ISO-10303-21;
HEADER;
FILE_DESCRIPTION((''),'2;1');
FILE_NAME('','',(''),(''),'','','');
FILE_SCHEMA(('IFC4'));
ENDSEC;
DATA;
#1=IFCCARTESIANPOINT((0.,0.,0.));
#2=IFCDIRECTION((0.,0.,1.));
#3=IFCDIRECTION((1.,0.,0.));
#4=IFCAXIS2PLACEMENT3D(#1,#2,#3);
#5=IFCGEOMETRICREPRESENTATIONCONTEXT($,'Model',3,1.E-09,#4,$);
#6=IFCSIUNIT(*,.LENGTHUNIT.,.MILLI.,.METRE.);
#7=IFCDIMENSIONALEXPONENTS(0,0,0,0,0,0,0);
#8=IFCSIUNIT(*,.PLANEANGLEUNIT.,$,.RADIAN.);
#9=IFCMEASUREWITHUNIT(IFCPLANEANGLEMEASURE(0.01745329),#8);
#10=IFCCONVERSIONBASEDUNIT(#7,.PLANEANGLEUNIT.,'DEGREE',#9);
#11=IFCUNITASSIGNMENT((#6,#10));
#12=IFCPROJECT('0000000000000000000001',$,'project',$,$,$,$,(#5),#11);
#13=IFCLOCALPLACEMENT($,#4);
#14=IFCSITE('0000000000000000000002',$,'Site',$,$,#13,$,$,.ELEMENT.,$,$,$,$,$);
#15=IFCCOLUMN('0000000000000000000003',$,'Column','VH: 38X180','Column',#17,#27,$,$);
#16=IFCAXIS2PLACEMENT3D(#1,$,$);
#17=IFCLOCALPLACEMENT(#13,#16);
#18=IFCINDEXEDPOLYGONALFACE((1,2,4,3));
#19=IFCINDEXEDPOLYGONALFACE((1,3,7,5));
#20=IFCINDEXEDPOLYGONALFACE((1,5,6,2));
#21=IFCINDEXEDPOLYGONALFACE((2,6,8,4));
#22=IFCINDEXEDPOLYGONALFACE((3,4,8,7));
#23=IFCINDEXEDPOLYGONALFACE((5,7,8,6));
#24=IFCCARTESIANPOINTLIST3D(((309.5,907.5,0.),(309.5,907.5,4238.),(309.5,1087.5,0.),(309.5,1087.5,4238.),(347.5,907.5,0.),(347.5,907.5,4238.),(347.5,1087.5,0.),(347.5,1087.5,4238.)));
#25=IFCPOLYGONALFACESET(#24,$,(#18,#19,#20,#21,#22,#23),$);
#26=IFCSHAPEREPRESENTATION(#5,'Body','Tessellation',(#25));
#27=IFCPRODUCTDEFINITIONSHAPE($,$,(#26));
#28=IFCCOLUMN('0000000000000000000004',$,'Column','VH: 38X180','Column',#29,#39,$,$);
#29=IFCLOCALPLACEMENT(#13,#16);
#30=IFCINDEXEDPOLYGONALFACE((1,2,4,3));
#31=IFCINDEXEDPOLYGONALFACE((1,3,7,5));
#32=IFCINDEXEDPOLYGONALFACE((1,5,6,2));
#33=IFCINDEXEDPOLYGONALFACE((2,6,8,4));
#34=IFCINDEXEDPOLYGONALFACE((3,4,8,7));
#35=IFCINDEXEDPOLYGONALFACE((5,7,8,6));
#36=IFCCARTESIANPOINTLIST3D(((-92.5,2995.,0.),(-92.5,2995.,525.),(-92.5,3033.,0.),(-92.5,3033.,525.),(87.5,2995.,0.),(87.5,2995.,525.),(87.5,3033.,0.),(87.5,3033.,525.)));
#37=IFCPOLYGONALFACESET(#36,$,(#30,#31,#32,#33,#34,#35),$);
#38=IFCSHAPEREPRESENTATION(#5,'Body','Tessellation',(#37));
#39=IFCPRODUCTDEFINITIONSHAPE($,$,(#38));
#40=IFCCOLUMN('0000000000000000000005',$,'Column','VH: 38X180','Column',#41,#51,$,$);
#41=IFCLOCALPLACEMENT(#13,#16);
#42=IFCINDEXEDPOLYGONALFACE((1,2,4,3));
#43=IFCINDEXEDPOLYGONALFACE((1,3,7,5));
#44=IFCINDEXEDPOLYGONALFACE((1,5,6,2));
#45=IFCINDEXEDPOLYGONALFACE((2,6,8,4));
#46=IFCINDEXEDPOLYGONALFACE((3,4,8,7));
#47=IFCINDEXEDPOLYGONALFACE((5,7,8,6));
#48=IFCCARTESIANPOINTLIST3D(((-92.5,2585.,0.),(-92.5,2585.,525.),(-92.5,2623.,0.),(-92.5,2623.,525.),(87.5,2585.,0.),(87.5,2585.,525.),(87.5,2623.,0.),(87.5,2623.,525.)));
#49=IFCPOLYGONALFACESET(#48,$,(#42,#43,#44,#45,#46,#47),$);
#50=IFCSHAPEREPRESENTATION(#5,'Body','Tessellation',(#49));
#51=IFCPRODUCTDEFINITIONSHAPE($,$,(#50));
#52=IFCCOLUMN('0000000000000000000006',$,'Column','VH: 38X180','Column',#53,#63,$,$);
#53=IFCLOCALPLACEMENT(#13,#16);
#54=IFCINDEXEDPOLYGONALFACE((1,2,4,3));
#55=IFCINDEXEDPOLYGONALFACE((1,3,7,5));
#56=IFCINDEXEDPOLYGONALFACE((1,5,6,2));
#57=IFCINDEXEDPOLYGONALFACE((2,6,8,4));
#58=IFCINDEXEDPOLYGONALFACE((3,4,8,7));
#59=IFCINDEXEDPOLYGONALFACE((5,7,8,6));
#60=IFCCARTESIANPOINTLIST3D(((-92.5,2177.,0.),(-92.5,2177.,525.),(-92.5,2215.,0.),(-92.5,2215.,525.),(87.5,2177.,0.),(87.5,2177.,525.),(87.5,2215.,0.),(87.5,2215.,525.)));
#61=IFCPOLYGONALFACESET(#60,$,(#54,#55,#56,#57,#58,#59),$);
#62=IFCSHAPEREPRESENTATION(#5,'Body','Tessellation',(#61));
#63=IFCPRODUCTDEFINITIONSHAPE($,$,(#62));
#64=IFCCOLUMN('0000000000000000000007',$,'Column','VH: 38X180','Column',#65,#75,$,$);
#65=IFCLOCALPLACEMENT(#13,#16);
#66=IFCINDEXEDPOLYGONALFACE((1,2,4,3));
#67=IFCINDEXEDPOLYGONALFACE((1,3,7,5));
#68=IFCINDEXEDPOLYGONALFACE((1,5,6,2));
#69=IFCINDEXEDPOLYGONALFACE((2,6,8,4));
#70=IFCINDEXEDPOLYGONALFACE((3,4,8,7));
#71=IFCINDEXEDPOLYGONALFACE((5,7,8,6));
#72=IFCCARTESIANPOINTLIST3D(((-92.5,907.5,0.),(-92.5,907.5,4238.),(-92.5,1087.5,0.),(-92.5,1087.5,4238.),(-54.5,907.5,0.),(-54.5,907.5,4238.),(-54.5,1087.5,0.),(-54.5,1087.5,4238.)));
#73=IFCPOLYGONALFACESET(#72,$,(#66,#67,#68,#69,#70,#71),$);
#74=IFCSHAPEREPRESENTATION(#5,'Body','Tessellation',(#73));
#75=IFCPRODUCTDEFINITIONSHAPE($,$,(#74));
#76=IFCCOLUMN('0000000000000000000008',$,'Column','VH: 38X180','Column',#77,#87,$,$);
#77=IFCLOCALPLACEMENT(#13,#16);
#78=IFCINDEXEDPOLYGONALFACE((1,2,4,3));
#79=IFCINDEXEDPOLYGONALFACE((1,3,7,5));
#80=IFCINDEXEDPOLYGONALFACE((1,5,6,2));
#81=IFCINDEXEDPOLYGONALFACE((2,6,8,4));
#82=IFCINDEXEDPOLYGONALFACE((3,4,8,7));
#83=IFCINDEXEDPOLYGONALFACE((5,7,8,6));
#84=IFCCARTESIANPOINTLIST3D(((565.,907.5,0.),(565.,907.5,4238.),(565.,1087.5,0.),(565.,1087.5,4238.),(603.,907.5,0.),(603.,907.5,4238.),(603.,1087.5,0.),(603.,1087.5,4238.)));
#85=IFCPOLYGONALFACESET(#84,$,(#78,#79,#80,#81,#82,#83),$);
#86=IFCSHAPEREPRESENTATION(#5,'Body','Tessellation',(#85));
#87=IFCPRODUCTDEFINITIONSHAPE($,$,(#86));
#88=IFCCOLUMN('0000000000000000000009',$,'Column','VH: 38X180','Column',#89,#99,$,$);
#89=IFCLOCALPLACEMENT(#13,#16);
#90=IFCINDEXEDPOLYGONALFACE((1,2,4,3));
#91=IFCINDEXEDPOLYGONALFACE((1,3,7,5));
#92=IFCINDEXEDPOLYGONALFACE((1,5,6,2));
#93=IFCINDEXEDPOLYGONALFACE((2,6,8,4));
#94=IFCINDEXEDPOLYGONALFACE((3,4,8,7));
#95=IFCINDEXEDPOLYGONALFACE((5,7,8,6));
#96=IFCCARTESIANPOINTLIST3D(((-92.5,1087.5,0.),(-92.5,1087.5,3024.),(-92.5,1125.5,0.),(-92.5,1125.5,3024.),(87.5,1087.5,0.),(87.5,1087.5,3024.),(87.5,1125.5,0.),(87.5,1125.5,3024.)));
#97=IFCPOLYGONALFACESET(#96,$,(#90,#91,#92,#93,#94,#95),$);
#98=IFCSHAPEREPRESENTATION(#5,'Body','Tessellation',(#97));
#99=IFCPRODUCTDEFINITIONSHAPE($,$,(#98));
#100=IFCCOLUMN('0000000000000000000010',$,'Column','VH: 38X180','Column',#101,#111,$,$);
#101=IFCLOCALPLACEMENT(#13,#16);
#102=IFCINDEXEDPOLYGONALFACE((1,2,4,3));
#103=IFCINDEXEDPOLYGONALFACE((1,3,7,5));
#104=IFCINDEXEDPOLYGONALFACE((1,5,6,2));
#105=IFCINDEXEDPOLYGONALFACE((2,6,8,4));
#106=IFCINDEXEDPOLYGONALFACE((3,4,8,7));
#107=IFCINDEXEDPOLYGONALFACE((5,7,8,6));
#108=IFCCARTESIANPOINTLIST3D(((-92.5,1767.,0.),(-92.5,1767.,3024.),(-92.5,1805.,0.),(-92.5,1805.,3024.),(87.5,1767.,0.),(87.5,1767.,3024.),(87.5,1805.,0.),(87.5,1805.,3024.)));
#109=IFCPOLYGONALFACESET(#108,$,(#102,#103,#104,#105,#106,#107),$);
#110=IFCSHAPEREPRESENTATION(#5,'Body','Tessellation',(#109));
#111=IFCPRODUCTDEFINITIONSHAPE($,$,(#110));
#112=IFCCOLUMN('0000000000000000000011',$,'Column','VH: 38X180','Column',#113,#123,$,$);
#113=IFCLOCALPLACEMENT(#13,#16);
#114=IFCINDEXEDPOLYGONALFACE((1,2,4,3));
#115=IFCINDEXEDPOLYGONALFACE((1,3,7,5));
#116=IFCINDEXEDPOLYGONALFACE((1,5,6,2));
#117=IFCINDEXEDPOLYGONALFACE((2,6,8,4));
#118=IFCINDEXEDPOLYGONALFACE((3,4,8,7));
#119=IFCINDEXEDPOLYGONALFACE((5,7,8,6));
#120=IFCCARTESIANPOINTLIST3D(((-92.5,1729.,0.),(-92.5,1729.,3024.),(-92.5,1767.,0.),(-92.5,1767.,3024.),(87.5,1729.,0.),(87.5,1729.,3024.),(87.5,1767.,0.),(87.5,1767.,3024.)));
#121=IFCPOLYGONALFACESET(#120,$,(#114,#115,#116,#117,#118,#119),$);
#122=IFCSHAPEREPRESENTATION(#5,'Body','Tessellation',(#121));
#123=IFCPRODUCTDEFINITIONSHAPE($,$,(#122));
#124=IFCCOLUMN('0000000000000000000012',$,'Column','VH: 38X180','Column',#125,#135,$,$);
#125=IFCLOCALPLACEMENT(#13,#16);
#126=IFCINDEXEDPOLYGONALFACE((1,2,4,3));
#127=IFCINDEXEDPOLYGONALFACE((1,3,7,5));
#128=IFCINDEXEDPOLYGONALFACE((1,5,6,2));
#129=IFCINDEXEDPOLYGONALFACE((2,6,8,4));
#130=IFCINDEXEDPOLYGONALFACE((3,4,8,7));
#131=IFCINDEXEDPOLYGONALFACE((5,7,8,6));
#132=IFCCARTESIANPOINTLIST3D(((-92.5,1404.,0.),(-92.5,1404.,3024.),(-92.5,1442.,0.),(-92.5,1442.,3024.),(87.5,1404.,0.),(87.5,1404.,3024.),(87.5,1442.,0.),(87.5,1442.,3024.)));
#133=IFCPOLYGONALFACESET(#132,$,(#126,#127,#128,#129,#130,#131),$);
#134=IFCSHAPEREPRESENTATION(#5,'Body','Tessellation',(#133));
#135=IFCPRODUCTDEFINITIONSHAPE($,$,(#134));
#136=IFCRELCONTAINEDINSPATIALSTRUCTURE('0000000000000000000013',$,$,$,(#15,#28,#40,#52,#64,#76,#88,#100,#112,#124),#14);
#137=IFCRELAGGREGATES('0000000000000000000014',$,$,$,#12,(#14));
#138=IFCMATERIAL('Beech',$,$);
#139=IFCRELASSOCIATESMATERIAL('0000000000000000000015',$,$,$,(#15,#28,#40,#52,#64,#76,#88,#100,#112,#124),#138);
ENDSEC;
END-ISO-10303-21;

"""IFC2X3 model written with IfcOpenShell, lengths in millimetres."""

from ifc_helpers import new_model, entity, si_unit, converted_unit, frame, origin, origin_with_axes, origin_2d, place, context, project, spatial, rectangle, extrude, material, element, save


model = new_model("IFC2X3")

# Units and contexts
model_context = context("Model", 3, precision=1e-09, world=origin_with_axes())
ifc_project = project(units=[si_unit("LENGTHUNIT", "METRE", prefix="MILLI"), converted_unit("PLANEANGLEUNIT", "DEGREE", entity("IfcPlaneAngleMeasure", 0.01745329), si_unit("PLANEANGLEUNIT", "RADIAN"), dimensions=[0, 0, 0, 0, 0, 0, 0])], contexts=[model_context])

# Site
site_placement = place(None, origin_with_axes())
site = spatial("IfcSite", under=ifc_project, at=site_placement, Name="Site", CompositionType="ELEMENT")

# Columns
ifc_material = material(Name="Beech")
column_placement = place(None, frame((328.5, 997.5, 0.0), z_axis=(0.0, 0.0, -1.0), x_axis=(-1.0, 0.0, 0.0)))
element("IfcColumn", 1, at=column_placement, inside=site, material=ifc_material, Name="Column", Description="VH: 38X180", ObjectType="Column", context=model_context, shape_type="SweptSolid", body=[
    extrude(rectangle(XDim=38.0, YDim=180.0, at=origin_2d()), origin(), (0.0, 0.0, -1.0), 4238.0),
])
for number, where, z_axis, x_axis, name in (
    (2, (-2.5, 3014.0, 0.0), (0.0, 0.0, -1.0), (0.0, -1.0, 0.0), "Column"),
    (3, (-2.5, 2604.0, 0.0), (0.0, 0.0, -1.0), (0.0, -1.0, 0.0), "Column"),
    (4, (-2.5, 2196.0, 0.0), (0.0, 0.0, -1.0), (0.0, -1.0, 0.0), "Column"),
):
    element("IfcColumn", number, at=place(None, frame(where, z_axis=z_axis, x_axis=x_axis)), inside=site, material=ifc_material, Name=name, Description="VH: 38X180", ObjectType="Column", context=model_context, shape_type="SweptSolid", body=[
        extrude(rectangle(XDim=38.0, YDim=180.0, at=origin_2d()), origin(), (0.0, 0.0, -1.0), 525.0),
    ])
for number, where, z_axis, x_axis, name in (
    (5, (-73.5, 997.5, 0.0), (0.0, 0.0, -1.0), (-1.0, 0.0, 0.0), "Column"),
    (6, (584.0, 997.5, 0.0), (0.0, 0.0, -1.0), (-1.0, 0.0, 0.0), "Column"),
):
    element("IfcColumn", number, at=place(None, frame(where, z_axis=z_axis, x_axis=x_axis)), inside=site, material=ifc_material, Name=name, Description="VH: 38X180", ObjectType="Column", context=model_context, shape_type="SweptSolid", body=[
        extrude(rectangle(XDim=38.0, YDim=180.0, at=origin_2d()), origin(), (0.0, 0.0, -1.0), 4238.0),
    ])
for number, where, z_axis, x_axis, name in (
    (7, (-2.5, 1106.5, 0.0), (0.0, 0.0, -1.0), (0.0, -1.0, 0.0), "Column"),
    (8, (-2.5, 1786.0, 0.0), (0.0, 0.0, -1.0), (0.0, -1.0, 0.0), "Column"),
    (9, (-2.5, 1748.0, 0.0), (0.0, 0.0, -1.0), (0.0, -1.0, 0.0), "Column"),
    (10, (-2.5, 1423.0, 0.0), (0.0, 0.0, -1.0), (0.0, -1.0, 0.0), "Column"),
):
    element("IfcColumn", number, at=place(None, frame(where, z_axis=z_axis, x_axis=x_axis)), inside=site, material=ifc_material, Name=name, Description="VH: 38X180", ObjectType="Column", context=model_context, shape_type="SweptSolid", body=[
        extrude(rectangle(XDim=38.0, YDim=180.0, at=origin_2d()), origin(), (0.0, 0.0, -1.0), 3024.0),
    ])

save(model, "model.ifc")
